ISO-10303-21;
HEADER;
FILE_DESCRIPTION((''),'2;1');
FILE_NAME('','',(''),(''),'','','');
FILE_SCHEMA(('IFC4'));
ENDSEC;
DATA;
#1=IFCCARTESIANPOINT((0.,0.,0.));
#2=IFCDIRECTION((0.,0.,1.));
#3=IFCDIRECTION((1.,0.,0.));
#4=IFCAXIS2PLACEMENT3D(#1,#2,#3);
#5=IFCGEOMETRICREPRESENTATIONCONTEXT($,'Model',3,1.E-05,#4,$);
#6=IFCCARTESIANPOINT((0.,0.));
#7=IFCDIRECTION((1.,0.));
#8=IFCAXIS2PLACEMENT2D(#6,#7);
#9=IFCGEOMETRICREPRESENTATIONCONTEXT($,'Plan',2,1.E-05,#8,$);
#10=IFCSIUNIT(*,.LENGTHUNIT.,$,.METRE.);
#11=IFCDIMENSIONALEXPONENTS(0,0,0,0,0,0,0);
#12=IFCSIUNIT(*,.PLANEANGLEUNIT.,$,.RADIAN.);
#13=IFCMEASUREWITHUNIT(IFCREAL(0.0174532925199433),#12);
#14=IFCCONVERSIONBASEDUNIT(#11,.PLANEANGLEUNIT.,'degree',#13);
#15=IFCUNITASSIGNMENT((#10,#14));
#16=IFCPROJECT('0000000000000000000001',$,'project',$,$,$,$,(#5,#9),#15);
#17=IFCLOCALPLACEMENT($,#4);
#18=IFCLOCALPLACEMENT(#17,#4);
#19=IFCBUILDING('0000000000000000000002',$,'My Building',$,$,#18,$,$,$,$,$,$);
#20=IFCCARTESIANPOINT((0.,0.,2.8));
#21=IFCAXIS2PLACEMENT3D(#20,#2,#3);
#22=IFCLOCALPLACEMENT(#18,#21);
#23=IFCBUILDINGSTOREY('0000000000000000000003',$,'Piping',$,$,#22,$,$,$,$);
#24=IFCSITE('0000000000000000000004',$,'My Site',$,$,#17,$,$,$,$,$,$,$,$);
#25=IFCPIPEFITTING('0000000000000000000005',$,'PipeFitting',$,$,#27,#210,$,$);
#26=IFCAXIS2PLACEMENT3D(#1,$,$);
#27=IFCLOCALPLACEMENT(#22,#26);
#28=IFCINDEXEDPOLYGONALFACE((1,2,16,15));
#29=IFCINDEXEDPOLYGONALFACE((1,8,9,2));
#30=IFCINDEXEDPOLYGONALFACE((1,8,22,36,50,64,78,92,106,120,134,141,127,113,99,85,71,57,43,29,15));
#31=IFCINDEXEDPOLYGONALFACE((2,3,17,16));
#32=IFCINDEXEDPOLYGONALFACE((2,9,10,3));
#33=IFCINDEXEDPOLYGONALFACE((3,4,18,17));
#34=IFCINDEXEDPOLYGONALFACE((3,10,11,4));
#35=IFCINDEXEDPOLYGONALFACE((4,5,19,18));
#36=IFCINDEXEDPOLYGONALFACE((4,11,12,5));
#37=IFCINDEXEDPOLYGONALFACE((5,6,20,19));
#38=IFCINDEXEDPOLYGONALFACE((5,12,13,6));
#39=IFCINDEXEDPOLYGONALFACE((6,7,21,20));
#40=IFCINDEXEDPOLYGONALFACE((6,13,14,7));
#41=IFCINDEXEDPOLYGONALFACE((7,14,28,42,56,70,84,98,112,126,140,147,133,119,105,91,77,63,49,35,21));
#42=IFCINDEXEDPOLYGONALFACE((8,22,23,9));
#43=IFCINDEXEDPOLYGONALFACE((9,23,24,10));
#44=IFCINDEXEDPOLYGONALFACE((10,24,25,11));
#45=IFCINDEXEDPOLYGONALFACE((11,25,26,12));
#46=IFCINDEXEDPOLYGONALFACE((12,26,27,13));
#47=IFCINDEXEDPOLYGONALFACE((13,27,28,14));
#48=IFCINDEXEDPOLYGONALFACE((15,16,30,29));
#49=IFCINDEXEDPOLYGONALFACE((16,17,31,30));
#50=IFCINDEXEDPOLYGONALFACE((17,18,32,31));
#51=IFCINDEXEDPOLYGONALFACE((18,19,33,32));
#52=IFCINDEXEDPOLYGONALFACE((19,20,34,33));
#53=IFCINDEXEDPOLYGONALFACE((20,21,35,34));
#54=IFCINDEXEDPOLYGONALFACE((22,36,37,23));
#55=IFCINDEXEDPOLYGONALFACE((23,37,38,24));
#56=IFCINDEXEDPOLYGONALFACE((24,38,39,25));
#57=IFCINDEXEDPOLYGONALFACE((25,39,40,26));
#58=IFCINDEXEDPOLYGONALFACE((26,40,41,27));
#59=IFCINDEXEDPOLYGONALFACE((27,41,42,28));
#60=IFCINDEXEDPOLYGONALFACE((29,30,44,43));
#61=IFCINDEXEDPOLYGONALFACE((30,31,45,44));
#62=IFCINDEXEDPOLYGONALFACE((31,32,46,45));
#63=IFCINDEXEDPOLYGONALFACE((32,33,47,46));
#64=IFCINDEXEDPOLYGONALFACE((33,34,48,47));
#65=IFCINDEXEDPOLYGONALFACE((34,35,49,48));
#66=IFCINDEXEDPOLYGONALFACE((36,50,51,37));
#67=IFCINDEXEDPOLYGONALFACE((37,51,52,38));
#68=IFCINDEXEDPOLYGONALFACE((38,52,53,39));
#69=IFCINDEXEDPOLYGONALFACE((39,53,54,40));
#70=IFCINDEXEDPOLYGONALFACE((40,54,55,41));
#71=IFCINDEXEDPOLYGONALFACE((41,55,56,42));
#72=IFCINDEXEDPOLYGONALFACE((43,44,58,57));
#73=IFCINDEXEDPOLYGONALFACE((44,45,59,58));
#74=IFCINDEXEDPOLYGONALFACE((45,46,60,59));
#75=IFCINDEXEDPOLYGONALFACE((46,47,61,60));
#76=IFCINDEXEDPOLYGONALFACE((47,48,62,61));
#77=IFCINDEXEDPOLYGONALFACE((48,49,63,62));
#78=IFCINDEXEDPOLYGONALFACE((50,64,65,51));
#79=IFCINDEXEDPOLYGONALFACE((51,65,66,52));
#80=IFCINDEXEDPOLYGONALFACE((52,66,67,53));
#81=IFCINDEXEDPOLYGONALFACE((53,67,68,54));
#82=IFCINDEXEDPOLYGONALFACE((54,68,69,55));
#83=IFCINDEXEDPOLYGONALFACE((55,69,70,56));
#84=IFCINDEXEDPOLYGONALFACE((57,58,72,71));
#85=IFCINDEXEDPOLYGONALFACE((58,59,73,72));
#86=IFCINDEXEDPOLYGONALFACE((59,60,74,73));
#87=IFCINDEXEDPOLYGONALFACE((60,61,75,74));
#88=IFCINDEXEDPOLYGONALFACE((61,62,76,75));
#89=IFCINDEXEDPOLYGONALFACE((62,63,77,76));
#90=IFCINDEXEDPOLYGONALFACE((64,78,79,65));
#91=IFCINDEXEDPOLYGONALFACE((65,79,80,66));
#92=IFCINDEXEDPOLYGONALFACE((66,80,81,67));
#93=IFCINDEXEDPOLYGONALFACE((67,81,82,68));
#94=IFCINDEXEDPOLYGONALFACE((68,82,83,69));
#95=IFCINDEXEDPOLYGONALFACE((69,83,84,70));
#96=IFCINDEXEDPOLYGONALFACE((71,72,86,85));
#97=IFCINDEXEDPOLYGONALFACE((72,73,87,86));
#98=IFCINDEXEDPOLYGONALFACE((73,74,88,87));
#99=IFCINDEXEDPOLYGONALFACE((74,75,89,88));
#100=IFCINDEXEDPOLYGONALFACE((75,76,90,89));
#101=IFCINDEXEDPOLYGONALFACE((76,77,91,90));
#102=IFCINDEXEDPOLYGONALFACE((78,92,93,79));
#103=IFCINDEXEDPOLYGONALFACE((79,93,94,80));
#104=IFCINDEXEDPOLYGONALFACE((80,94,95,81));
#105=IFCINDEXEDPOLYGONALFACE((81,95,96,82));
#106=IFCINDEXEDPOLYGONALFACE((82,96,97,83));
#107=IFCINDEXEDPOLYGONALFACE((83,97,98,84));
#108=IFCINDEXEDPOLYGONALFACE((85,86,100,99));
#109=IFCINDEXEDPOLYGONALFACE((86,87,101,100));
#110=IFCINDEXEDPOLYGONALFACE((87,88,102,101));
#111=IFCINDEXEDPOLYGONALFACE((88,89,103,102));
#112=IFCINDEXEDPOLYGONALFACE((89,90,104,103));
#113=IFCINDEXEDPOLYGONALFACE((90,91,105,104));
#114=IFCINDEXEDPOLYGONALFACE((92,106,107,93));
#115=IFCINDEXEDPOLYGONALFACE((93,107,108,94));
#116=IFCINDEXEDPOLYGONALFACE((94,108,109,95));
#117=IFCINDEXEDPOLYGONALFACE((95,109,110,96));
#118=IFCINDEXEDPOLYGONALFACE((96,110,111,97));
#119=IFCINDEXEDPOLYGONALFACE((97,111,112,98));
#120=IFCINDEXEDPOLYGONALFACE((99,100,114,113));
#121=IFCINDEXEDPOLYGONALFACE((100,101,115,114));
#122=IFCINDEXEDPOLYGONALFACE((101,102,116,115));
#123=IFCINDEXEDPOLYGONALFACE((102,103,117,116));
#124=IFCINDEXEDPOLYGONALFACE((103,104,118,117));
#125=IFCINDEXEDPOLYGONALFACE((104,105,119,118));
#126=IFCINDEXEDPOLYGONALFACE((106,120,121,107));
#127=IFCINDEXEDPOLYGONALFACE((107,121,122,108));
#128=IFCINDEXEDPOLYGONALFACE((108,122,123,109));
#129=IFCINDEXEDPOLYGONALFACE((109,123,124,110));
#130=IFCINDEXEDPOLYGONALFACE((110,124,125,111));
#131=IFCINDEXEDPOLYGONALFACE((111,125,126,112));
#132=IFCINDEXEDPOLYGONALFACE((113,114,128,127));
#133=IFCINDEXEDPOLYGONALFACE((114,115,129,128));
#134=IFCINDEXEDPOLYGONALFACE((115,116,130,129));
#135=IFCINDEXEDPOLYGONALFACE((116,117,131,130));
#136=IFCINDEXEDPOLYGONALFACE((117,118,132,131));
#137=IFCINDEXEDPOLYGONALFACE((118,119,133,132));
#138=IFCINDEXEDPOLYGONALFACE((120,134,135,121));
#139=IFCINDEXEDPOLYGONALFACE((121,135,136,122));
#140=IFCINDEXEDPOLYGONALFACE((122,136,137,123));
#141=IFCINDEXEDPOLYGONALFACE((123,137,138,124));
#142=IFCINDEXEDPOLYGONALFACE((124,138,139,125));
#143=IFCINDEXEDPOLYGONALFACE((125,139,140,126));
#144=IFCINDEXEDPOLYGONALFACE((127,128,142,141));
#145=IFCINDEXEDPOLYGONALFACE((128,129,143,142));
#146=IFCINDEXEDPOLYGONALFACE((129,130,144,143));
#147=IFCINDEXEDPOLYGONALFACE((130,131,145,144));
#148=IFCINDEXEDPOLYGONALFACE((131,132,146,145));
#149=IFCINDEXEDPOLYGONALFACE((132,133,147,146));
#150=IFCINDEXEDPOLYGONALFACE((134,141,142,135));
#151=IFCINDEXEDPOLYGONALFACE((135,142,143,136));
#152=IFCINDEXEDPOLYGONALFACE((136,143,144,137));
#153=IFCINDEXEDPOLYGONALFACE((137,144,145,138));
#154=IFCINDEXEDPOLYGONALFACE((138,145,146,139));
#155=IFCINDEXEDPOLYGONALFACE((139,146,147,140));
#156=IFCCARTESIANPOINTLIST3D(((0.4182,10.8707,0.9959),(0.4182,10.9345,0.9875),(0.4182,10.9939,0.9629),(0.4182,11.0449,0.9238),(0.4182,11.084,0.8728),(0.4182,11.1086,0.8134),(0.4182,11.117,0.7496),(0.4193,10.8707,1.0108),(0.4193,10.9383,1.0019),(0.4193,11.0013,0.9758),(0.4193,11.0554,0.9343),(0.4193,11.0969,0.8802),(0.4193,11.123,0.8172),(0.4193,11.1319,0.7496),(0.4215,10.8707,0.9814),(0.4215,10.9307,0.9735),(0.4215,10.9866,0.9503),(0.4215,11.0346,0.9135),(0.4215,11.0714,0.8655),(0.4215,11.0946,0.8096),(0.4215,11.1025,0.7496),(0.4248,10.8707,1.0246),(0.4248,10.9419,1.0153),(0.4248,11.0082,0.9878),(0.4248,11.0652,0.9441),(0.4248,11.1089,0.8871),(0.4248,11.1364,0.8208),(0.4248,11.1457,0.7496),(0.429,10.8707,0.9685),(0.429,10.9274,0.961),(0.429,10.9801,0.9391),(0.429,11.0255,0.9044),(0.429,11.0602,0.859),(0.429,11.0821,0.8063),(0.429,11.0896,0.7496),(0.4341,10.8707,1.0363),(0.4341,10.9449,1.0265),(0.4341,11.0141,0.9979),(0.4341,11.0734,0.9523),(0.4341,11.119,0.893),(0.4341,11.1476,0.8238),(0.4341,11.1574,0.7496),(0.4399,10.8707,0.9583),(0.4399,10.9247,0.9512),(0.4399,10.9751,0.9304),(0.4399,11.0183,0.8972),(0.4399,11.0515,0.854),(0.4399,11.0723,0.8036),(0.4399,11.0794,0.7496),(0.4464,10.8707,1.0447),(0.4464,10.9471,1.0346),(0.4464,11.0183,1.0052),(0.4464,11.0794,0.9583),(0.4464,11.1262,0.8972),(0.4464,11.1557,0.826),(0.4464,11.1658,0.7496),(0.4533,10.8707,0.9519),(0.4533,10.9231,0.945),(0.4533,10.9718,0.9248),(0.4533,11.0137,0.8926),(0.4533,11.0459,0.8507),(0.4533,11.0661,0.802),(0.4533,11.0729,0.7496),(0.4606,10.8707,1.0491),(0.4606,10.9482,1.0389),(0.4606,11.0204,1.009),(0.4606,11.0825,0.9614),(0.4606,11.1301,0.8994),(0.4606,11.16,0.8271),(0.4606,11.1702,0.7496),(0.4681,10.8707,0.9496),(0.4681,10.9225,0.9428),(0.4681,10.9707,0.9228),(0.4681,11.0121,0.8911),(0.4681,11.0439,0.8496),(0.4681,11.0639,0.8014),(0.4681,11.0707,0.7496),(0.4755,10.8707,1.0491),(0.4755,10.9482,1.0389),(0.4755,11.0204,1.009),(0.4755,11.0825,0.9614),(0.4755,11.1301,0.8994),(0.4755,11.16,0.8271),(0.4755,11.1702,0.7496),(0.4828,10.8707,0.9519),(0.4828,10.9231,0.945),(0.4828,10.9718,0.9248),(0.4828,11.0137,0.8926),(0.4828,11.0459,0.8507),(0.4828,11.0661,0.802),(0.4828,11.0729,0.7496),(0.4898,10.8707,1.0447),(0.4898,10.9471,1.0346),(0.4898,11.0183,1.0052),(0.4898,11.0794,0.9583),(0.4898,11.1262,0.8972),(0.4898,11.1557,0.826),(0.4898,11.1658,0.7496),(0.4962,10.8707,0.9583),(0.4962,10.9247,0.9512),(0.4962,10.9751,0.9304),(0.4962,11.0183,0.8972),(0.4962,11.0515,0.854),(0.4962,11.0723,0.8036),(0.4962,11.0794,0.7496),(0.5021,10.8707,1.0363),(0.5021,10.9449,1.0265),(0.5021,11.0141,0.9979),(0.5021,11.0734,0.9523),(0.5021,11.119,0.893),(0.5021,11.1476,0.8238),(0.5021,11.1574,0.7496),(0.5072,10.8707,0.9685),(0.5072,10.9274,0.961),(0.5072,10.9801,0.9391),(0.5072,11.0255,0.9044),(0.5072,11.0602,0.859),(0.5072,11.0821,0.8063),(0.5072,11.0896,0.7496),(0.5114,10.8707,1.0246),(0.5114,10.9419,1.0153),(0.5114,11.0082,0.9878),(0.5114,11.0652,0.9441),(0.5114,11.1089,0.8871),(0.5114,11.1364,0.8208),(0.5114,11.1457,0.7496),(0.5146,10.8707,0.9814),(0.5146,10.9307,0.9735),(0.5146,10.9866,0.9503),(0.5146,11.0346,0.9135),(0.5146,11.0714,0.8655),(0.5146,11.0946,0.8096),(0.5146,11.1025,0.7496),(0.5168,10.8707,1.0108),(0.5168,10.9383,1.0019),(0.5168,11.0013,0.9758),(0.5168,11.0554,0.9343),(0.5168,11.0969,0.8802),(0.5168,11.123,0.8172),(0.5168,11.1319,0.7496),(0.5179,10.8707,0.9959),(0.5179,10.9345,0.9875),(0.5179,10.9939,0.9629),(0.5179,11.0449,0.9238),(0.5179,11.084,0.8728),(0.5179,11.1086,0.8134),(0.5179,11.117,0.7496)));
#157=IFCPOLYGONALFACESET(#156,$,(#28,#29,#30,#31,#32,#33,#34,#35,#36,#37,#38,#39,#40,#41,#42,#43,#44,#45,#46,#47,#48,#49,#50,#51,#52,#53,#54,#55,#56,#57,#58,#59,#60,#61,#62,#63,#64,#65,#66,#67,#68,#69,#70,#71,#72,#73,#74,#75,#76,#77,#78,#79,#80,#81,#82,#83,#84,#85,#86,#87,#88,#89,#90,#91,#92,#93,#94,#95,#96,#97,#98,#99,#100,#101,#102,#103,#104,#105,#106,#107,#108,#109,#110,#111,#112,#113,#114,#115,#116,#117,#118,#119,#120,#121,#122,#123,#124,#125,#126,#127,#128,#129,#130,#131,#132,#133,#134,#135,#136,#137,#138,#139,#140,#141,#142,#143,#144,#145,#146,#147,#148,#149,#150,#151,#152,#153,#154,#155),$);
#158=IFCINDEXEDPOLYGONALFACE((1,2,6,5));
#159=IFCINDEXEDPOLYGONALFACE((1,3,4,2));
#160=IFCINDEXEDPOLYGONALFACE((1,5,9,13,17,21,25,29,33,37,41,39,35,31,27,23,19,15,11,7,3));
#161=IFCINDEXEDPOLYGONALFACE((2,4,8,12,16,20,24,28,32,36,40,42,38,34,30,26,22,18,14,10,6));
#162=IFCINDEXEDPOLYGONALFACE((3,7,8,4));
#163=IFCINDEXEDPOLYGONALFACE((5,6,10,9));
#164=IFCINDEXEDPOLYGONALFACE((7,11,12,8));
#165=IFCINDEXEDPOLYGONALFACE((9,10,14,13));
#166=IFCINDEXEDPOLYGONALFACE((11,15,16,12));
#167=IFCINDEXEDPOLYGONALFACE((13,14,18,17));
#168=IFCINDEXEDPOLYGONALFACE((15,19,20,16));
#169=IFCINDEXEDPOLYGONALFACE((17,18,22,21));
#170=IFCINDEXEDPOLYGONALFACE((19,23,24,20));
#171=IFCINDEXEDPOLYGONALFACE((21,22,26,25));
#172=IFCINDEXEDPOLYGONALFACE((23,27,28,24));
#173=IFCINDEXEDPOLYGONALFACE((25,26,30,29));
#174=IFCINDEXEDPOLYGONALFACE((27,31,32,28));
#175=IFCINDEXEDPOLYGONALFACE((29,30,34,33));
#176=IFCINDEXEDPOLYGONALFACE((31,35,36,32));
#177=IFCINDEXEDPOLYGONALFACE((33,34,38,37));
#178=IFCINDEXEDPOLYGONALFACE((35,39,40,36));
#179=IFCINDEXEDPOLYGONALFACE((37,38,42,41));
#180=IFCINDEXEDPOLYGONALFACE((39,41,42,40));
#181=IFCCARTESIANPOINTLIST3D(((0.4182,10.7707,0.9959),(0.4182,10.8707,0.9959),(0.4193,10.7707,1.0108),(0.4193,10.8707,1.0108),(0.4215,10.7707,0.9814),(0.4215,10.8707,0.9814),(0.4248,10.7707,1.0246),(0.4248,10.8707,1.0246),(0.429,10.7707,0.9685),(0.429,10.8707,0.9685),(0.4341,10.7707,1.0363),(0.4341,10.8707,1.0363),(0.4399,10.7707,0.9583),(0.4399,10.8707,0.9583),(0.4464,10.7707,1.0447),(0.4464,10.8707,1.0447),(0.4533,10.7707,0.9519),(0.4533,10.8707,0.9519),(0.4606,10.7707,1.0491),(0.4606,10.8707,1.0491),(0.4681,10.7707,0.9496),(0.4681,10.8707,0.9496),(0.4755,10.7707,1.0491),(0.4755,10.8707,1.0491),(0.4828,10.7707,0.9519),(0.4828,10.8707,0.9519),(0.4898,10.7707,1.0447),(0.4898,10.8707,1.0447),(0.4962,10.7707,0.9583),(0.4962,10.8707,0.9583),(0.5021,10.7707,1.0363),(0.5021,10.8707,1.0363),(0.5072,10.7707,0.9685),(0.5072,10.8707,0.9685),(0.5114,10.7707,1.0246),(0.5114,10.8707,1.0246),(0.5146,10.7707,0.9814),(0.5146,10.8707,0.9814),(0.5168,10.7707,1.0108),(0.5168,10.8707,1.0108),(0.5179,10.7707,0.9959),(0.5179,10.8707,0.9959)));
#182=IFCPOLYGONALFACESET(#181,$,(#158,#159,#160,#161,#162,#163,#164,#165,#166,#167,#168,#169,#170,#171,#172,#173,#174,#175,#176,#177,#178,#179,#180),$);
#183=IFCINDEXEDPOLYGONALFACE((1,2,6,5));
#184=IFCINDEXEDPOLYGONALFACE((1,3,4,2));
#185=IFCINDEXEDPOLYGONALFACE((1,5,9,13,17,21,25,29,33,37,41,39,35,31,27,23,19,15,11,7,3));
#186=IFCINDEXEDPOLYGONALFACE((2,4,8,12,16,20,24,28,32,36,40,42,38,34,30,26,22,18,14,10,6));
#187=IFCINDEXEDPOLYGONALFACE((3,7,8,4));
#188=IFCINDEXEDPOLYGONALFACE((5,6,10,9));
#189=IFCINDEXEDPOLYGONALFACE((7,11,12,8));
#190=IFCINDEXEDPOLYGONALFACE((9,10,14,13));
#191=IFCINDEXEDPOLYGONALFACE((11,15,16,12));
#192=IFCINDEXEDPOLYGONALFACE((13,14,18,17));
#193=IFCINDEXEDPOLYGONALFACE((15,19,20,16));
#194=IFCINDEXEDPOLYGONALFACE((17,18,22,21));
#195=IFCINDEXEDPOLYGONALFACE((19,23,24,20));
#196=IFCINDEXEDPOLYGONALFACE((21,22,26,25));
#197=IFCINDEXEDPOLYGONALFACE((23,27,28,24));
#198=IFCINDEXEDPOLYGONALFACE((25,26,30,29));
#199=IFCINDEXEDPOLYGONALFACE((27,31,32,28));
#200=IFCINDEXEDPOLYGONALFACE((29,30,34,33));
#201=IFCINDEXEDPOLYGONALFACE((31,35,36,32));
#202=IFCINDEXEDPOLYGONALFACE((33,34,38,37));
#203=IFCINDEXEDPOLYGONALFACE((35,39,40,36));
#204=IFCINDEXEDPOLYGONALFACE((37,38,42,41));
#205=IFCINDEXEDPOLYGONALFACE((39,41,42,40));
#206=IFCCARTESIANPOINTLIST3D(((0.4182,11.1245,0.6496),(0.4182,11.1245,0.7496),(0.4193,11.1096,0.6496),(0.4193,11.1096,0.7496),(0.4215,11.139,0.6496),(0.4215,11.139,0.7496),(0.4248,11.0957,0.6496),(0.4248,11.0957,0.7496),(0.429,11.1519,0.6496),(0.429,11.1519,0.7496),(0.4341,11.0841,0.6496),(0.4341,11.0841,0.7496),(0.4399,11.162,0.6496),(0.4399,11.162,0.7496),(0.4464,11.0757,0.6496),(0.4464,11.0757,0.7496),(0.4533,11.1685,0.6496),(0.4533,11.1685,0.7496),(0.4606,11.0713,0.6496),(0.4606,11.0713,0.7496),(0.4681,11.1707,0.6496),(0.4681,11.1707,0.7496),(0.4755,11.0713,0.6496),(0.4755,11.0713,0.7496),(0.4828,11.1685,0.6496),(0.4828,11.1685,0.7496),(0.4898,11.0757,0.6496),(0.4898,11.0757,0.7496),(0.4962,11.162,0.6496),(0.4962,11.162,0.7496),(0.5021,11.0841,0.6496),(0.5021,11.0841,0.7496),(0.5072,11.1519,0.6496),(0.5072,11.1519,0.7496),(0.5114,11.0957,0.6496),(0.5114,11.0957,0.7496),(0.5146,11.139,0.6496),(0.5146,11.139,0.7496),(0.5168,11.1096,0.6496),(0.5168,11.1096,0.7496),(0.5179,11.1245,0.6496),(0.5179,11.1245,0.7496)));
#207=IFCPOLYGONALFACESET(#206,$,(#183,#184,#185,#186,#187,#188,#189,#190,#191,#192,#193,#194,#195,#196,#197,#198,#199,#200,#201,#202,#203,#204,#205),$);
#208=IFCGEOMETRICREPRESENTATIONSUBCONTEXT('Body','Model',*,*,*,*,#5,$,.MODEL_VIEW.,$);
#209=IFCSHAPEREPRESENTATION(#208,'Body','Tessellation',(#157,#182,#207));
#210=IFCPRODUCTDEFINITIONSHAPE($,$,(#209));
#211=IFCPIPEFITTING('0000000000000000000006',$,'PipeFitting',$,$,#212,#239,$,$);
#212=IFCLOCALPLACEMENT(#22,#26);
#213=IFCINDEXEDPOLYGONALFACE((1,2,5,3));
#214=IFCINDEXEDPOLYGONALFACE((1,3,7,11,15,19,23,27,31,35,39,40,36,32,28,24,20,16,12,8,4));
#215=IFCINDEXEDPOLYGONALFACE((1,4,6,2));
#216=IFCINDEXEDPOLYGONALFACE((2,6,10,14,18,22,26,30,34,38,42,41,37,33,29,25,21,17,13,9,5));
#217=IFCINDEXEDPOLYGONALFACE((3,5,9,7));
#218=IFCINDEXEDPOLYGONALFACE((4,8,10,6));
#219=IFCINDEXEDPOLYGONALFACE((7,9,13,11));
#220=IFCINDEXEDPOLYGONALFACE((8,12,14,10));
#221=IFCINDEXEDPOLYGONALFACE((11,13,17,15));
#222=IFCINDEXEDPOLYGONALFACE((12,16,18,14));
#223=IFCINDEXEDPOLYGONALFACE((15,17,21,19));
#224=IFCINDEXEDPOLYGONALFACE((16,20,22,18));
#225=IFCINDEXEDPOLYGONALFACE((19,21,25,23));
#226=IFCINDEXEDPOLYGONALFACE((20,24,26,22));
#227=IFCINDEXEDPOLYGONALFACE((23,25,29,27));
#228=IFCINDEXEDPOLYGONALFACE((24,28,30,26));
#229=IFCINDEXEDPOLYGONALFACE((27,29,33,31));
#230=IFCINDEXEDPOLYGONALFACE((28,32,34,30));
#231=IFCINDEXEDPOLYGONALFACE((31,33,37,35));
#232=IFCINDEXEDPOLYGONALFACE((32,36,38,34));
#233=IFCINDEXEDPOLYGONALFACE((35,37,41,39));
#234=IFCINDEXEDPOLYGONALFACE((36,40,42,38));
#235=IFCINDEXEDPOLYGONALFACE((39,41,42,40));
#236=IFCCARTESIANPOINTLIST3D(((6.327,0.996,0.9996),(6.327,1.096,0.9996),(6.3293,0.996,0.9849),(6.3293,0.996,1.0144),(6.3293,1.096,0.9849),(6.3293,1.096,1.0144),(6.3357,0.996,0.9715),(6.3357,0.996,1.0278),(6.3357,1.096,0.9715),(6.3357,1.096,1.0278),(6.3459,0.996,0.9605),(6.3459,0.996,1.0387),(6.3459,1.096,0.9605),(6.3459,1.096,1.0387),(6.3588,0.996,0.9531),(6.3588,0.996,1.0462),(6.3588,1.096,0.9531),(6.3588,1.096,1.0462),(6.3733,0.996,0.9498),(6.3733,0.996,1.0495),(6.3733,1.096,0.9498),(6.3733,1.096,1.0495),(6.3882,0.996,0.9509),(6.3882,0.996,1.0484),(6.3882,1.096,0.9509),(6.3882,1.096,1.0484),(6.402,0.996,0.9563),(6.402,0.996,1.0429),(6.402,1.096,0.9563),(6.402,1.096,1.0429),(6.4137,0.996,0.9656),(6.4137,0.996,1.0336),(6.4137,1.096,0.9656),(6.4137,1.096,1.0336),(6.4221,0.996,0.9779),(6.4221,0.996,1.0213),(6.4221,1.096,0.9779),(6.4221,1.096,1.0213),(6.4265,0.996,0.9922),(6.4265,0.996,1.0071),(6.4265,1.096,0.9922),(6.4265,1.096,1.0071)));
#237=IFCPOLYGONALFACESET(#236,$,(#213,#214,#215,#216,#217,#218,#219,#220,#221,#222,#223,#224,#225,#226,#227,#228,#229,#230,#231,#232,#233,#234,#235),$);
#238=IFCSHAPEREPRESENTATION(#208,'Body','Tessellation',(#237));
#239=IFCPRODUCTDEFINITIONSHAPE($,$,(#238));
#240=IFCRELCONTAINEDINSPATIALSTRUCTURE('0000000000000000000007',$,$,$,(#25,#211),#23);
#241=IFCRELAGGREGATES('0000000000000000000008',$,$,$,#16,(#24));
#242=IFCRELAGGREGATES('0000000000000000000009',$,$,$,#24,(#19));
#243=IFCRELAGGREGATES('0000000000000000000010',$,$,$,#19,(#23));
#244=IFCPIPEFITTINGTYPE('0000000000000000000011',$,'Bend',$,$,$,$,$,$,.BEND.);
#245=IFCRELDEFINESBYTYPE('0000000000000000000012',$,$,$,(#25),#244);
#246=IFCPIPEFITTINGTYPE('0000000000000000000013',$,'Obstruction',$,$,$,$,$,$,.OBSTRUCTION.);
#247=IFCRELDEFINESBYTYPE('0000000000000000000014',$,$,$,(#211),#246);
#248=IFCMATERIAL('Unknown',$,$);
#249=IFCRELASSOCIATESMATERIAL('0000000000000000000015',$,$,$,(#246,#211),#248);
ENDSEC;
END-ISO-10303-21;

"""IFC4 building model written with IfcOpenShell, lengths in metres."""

from ifc_helpers import new_model, entity, si_unit, converted_unit, frame, origin_with_axes, origin_2d_with_axis, place, context, subcontext, project, spatial, circle, extrude, source, transform, mapped, material, material_profile, profile_set, profile_usage, type_object, type_shapes, element, save


model = new_model("IFC4")

# Units and contexts
model_context = context("Model", 3, precision=1e-05, world=origin_with_axes())
plan_context = context("Plan", 2, precision=1e-05, world=origin_2d_with_axis())
body_context = subcontext(model_context, "Body", "Model", "MODEL_VIEW")
ifc_project = project(units=[si_unit("LENGTHUNIT", "METRE"), converted_unit("PLANEANGLEUNIT", "degree", entity("IfcReal", 0.0174532925199433), si_unit("PLANEANGLEUNIT", "RADIAN"), dimensions=[0, 0, 0, 0, 0, 0, 0])], contexts=[model_context, plan_context])

# Site, building, storey
site_placement = place(None, origin_with_axes())
site = spatial("IfcSite", under=ifc_project, at=site_placement, Name="My Site")
building_placement = place(site_placement, origin_with_axes())
building = spatial("IfcBuilding", under=site, at=building_placement, Name="My Building")
storey_placement = place(building_placement, frame((0.0, 0.0, 2.8), z_axis=(0.0, 0.0, 1.0), x_axis=(1.0, 0.0, 0.0)))
storey = spatial("IfcBuildingStorey", under=building, at=storey_placement, Name="Piping")

# Shared definitions
ifc_material = material(Name="Unknown")

# Pipe fittings
pipe_fitting_type_1 = type_object("IfcPipeFittingType", Name="Bend", PredefinedType="BEND")
shared_shape = source(origin_with_axes(), body_context, "Body", "SolidModel", [
    entity("IfcSweptDiskSolid", entity("IfcIndexedPolyCurve", entity("IfcCartesianPointList3D", [[0.0, 0.0, 0.1], [0.0732, 0.0, 0.2768], [0.25, 0.0, 0.35]]), [entity("IfcArcIndex", [1, 2, 3])]), 0.05),
    extrude(circle(Radius=0.05), origin_with_axes(), (0.0, 0.0, 1.0), 0.1),
    extrude(circle(Radius=0.05), frame((0.25, 0.0, 0.35), z_axis=(1.0, 0.0, 0.0), x_axis=(0.0, 0.0, 1.0)), (0.0, 0.0, 1.0), 0.1),
])
type_shapes(pipe_fitting_type_1, [shared_shape])
for number, where, z_axis, x_axis, name in (
    (1, (0.4681, 10.7707, 0.9996), (0.0, 1.0, 0.0), (0.0, 0.0, -1.0), "PipeFitting"),
):
    element("IfcPipeFitting", number, at=place(storey_placement, frame(where, z_axis=z_axis, x_axis=x_axis)), inside=storey, type_object=pipe_fitting_type_1, Name=name, context=body_context, shape_type="MappedRepresentation", body=[
        mapped(shared_shape, transform((0.0, 0.0, 0.0), x_axis=(1.0, 0.0, 0.0), y_axis=(0.0, 1.0, 0.0), z_axis=(0.0, 0.0, 1.0), scale=1.0)),
    ])
ifc_material_profile_1 = material_profile(ifc_material, circle(Radius=0.05))
ifc_profile_set_1 = profile_set([ifc_material_profile_1])
ifc_profile_usage_1 = profile_usage(ifc_profile_set_1, cardinal=5)
pipe_fitting_type_2 = type_object("IfcPipeFittingType", Name="Obstruction", PredefinedType="OBSTRUCTION", material=ifc_profile_set_1)
pipe_fitting_1_placement = place(storey_placement, frame((6.377, 0.996, 0.9996), z_axis=(0.0, 1.0, 0.0), x_axis=(-1.0, 0.0, 0.0)))
element("IfcPipeFitting", 2, at=pipe_fitting_1_placement, inside=storey, type_object=pipe_fitting_type_2, material=ifc_profile_usage_1, Name="PipeFitting", context=body_context, shape_type="SweptSolid", body=[
    extrude(circle(Radius=0.05), origin_with_axes(), (0.0, 0.0, 1.0), 0.1),
])

save(model, "model.ifc")
